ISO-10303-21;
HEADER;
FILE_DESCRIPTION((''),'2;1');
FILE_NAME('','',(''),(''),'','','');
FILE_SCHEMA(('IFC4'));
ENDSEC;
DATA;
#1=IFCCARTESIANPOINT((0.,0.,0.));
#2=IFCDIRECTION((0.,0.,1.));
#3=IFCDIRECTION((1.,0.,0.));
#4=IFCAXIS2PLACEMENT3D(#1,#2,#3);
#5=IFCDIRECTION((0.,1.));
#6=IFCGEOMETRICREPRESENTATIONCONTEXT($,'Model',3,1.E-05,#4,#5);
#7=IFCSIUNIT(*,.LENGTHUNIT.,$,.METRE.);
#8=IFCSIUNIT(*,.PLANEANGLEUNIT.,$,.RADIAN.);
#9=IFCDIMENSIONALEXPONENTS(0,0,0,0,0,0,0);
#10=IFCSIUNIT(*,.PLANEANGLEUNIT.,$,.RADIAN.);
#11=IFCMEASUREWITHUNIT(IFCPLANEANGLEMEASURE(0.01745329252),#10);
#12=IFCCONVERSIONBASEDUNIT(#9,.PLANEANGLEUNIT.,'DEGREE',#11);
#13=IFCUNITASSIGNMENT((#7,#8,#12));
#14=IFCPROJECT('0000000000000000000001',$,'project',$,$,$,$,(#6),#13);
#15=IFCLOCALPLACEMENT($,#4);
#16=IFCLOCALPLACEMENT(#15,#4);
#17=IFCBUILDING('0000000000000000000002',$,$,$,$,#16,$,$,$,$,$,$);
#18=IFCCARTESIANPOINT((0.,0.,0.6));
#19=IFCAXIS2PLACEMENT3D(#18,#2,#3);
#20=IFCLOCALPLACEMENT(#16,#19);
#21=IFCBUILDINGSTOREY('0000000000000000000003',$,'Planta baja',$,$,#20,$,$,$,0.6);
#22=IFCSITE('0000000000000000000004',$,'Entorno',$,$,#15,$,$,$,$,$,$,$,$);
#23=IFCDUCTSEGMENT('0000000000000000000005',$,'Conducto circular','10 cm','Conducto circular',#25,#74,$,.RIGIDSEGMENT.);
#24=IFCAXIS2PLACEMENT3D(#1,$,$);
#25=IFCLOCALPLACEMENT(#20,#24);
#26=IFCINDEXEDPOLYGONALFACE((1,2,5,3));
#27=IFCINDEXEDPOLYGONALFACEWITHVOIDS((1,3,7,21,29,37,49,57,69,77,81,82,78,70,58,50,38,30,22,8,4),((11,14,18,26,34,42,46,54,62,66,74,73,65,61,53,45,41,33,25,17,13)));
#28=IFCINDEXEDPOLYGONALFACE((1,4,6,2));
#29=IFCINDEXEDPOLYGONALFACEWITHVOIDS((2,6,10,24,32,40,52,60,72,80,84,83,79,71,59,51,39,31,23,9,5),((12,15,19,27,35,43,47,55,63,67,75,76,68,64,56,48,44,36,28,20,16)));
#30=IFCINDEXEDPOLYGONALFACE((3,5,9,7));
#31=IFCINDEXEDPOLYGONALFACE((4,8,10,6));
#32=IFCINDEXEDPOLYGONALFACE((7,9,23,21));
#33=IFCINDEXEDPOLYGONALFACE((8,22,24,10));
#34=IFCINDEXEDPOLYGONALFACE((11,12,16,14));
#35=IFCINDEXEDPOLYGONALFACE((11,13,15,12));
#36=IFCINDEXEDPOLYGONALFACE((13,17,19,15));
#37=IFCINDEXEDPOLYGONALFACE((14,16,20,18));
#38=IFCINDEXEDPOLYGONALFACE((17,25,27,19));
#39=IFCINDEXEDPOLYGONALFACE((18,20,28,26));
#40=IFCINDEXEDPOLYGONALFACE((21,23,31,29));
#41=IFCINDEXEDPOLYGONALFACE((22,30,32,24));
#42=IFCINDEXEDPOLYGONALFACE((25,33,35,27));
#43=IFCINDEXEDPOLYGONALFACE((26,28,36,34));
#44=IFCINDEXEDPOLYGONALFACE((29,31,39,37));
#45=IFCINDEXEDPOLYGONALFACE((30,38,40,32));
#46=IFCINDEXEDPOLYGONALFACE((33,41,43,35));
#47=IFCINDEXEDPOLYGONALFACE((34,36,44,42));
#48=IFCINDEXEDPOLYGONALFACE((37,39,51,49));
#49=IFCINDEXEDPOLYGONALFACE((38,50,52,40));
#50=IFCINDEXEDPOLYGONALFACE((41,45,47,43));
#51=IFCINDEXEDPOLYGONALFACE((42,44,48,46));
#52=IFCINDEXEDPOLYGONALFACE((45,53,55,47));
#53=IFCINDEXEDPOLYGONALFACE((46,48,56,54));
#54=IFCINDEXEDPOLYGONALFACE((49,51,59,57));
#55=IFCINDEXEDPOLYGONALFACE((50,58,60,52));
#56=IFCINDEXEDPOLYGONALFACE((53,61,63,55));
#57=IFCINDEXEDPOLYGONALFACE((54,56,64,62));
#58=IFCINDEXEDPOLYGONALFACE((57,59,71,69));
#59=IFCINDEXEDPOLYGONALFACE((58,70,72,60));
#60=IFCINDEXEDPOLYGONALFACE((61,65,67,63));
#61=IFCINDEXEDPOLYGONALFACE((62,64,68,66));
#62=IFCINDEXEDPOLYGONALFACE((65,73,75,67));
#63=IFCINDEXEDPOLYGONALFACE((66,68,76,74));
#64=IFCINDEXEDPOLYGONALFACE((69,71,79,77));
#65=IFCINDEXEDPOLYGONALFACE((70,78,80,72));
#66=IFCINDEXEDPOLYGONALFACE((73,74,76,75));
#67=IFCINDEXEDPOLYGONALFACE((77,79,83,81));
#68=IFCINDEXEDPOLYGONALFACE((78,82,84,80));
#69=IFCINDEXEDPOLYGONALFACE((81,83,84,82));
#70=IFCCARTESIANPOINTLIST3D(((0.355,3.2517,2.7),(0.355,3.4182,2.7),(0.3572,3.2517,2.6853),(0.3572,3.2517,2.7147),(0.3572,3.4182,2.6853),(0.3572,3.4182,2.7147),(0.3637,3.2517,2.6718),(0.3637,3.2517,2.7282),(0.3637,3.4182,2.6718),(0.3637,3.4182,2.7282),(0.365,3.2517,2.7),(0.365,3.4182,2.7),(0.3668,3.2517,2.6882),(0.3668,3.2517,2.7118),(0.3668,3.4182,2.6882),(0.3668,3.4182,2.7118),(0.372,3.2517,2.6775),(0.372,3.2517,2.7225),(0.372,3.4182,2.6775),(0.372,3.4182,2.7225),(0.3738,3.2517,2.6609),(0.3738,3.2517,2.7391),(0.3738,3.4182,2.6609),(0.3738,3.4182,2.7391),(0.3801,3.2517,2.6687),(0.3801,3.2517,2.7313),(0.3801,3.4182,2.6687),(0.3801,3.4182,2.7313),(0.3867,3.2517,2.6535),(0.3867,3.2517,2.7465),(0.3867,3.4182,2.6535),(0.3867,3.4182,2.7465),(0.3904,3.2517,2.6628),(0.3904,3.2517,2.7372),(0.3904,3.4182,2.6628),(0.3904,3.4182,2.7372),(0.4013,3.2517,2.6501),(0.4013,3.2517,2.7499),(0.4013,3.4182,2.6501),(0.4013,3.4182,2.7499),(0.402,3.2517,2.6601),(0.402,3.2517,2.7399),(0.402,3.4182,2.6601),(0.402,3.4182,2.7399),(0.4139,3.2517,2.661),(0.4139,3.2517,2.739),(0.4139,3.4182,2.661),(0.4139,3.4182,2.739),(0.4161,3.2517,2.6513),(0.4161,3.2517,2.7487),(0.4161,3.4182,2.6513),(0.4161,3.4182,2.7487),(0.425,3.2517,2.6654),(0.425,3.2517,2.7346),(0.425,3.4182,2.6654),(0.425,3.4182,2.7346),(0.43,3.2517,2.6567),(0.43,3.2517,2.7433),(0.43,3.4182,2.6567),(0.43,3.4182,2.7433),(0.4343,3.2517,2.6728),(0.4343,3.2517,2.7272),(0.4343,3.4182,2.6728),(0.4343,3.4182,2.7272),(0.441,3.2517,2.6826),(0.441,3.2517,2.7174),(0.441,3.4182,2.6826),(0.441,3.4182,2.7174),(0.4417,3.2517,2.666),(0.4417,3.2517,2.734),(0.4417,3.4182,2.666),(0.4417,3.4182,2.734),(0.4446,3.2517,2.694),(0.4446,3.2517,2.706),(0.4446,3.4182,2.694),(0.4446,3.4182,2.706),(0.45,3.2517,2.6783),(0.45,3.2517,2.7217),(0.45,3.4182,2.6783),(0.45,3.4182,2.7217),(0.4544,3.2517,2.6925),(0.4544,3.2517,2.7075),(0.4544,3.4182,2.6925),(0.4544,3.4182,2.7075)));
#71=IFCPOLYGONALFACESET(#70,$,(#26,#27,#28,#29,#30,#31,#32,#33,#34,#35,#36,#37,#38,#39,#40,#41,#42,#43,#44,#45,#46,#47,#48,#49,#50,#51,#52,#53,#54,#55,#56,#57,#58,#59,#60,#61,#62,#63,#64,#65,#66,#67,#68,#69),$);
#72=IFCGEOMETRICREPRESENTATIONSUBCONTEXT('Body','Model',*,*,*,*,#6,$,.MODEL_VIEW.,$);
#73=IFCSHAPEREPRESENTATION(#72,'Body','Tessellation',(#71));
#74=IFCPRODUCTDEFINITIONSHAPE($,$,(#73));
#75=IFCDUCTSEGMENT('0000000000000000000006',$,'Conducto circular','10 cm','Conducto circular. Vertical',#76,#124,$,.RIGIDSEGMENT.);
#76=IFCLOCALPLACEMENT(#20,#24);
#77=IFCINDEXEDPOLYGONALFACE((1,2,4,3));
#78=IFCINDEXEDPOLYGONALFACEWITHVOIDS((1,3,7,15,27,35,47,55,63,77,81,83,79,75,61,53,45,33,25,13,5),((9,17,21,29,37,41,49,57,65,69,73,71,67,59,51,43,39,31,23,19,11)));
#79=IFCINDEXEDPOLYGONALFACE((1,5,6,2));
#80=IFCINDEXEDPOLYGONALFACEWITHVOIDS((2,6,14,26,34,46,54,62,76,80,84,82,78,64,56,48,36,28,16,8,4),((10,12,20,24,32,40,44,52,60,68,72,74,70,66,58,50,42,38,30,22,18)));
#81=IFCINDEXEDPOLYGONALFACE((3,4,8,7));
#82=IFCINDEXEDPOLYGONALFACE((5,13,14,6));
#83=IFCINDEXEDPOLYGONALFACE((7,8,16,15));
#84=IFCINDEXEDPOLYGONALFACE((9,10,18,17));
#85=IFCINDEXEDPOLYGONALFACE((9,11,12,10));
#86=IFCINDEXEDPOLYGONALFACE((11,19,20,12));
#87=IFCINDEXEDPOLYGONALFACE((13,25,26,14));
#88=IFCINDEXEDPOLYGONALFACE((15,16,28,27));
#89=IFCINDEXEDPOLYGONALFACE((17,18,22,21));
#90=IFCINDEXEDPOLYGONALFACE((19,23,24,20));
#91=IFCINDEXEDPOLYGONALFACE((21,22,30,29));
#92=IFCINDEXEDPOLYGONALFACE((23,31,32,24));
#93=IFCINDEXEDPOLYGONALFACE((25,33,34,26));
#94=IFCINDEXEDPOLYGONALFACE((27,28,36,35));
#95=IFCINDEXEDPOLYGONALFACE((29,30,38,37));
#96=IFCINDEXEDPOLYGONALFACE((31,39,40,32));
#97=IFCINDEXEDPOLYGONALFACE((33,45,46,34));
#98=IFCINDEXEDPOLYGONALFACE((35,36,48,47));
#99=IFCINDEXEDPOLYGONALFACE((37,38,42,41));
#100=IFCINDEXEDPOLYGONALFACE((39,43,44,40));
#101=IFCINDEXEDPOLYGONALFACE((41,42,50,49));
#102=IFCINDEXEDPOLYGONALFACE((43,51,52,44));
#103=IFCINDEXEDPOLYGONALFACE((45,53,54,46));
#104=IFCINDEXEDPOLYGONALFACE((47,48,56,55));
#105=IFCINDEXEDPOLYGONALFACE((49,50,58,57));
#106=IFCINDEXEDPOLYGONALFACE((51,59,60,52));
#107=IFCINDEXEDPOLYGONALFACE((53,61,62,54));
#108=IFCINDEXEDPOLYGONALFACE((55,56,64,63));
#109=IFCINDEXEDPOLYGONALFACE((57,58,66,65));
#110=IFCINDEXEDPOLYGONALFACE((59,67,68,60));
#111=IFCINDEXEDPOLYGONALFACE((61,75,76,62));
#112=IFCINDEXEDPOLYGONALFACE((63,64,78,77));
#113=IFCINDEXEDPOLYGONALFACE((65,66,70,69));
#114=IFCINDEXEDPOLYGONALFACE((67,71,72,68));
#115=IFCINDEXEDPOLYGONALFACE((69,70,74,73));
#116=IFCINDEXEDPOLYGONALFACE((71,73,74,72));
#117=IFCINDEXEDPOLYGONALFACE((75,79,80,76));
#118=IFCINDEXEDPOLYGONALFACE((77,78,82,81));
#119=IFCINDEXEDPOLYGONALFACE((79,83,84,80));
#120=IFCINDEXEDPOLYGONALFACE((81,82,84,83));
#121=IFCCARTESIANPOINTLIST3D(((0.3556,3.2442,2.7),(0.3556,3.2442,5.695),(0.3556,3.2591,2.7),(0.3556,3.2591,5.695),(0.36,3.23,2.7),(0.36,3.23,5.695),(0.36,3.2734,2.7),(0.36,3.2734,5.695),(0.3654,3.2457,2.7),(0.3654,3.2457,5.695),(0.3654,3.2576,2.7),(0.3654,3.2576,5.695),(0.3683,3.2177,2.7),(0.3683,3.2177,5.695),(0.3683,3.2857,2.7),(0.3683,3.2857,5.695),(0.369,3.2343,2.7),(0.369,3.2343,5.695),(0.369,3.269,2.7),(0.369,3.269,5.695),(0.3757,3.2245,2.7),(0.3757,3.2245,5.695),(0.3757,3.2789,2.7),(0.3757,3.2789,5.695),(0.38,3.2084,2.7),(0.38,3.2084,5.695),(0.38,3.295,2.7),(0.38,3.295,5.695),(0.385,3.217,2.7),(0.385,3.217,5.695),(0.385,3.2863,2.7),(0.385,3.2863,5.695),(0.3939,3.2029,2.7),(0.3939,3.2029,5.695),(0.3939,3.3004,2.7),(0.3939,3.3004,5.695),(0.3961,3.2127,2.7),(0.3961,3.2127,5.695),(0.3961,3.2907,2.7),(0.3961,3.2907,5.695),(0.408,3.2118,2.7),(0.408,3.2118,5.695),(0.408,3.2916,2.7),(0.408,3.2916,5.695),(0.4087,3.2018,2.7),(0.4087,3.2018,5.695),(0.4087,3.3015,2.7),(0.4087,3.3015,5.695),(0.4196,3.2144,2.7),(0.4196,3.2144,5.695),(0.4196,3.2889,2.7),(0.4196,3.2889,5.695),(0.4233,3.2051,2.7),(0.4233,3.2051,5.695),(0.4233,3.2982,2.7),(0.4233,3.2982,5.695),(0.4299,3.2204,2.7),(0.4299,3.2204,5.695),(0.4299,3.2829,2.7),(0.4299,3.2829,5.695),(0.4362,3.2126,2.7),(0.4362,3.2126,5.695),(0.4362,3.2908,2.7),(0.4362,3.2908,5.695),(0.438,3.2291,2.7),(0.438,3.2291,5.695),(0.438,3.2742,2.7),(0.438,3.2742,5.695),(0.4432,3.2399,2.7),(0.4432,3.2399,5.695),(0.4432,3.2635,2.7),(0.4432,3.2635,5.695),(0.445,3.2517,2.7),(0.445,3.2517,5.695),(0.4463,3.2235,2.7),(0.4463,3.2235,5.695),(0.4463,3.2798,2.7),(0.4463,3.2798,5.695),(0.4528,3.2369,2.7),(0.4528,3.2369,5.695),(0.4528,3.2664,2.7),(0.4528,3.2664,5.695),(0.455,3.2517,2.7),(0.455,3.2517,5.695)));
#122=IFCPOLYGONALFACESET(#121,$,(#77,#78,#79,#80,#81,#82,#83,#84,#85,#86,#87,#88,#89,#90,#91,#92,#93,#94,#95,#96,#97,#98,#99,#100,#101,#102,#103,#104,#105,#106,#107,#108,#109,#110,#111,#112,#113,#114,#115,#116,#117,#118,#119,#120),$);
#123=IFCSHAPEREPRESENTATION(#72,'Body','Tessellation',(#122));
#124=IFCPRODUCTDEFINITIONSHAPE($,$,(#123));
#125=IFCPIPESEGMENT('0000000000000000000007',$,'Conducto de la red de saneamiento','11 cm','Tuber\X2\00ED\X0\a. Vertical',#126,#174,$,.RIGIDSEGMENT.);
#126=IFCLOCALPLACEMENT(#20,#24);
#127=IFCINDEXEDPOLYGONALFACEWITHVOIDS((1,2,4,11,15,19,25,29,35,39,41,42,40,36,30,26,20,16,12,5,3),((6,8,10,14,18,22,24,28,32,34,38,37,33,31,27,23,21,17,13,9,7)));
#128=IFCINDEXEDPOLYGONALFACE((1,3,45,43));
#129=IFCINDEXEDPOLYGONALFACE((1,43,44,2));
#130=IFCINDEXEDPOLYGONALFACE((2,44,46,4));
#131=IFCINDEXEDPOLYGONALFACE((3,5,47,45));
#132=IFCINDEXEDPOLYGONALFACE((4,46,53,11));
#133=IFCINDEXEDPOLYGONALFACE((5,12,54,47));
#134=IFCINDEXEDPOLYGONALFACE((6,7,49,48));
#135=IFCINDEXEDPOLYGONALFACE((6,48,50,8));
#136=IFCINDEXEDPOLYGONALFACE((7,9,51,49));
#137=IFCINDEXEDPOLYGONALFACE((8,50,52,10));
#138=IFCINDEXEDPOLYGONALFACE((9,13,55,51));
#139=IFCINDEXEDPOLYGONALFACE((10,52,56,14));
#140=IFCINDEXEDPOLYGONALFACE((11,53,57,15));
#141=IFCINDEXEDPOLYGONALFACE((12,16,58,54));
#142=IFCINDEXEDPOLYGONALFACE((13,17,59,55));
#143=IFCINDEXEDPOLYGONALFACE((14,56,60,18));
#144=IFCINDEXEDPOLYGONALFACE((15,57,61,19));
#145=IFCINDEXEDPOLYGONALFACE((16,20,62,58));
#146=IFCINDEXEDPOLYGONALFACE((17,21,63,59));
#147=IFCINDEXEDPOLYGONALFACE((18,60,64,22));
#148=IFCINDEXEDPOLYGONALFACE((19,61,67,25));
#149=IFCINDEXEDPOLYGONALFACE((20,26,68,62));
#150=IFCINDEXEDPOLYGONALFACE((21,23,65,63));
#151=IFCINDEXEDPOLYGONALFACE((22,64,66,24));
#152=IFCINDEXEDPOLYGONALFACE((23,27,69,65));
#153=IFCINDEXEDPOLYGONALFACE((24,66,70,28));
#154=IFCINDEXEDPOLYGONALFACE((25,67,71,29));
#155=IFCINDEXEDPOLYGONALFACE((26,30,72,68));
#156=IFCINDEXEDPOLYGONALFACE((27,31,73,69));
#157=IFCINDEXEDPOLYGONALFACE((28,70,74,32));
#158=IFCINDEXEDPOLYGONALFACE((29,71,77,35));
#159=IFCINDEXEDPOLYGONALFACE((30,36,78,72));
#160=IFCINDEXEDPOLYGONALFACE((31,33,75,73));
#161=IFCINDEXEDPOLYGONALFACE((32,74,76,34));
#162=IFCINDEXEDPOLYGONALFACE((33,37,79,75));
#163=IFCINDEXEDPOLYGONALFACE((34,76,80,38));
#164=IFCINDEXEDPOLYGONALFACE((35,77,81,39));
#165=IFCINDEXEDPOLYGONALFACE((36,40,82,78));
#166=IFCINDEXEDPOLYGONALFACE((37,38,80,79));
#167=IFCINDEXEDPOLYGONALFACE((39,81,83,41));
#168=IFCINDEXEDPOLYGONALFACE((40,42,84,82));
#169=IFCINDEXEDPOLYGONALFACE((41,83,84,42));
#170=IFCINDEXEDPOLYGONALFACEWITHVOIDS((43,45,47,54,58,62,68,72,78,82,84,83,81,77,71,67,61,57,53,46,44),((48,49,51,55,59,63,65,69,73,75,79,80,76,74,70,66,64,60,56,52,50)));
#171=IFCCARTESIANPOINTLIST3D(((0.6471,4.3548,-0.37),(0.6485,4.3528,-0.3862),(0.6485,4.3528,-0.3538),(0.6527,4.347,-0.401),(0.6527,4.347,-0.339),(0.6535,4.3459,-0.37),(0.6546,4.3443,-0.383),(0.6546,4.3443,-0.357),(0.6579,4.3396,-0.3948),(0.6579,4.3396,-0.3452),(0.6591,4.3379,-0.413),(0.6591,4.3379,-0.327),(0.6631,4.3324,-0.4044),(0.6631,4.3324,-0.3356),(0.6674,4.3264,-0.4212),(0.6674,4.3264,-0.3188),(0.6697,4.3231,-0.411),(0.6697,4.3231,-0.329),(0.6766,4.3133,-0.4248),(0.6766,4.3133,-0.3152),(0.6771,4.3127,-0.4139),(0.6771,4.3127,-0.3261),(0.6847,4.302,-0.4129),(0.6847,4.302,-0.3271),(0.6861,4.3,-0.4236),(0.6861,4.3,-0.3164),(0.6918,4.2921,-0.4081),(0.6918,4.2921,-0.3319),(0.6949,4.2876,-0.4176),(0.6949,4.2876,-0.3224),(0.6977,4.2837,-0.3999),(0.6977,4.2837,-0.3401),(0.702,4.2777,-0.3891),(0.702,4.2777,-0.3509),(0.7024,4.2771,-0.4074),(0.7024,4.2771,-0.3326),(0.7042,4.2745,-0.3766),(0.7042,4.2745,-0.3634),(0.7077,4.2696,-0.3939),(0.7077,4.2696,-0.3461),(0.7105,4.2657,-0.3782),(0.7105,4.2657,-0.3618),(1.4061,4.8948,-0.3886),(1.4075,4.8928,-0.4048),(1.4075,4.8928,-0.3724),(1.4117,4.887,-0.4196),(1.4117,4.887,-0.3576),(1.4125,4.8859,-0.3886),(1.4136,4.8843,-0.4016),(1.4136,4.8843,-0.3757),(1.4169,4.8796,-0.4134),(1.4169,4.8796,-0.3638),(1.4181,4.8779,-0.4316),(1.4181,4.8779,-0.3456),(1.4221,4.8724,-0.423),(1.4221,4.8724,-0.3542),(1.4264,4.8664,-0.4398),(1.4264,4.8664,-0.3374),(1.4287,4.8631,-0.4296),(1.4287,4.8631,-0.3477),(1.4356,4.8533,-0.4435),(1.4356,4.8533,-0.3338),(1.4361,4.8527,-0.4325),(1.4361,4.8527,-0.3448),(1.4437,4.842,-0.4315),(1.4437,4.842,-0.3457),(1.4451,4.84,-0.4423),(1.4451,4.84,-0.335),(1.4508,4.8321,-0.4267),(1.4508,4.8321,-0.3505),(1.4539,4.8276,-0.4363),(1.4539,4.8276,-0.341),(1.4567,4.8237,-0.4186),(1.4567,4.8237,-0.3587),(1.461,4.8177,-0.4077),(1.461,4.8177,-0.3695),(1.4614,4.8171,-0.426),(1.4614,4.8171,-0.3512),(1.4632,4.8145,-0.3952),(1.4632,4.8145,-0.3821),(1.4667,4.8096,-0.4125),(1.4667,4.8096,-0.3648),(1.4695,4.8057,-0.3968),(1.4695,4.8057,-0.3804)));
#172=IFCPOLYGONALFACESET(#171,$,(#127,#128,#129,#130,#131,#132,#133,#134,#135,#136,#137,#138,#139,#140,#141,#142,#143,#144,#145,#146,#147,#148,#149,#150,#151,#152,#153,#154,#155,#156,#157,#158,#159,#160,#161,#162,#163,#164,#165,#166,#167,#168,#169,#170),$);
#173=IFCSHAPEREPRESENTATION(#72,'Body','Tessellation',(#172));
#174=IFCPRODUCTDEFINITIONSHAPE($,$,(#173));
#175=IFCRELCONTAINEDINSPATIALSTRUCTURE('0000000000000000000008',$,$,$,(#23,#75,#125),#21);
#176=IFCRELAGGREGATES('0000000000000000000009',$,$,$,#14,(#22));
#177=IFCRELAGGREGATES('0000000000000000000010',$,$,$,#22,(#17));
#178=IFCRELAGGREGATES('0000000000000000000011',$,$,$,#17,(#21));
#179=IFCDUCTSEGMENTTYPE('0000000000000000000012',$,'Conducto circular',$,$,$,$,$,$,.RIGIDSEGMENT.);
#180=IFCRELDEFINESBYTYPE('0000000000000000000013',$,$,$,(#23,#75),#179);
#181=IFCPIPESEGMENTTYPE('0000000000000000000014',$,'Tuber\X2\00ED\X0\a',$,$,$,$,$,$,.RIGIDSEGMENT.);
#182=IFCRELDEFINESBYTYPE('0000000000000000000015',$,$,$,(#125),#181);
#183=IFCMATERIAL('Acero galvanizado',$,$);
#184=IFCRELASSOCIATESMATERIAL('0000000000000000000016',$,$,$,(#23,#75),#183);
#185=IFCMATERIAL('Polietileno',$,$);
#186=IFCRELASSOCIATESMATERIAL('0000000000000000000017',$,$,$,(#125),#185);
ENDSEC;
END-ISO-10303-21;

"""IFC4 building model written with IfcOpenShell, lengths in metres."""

from ifc_helpers import new_model, entity, si_unit, converted_unit, direction, frame, origin_with_axes, origin_2d_with_axis, place, context, subcontext, project, spatial, hollow_circle, extrude, material, type_object, element, save


model = new_model("IFC4")

# Units and contexts
model_context = context("Model", 3, precision=1e-05, world=origin_with_axes(), true_north=direction((0.0, 1.0)))
body_context = subcontext(model_context, "Body", "Model", "MODEL_VIEW")
ifc_project = project(units=[si_unit("LENGTHUNIT", "METRE"), si_unit("PLANEANGLEUNIT", "RADIAN"), converted_unit("PLANEANGLEUNIT", "DEGREE", entity("IfcPlaneAngleMeasure", 0.01745329252), si_unit("PLANEANGLEUNIT", "RADIAN"), dimensions=[0, 0, 0, 0, 0, 0, 0])], contexts=[model_context])

# Site, building, storey
site_placement = place(None, origin_with_axes())
site = spatial("IfcSite", under=ifc_project, at=site_placement, Name="Entorno")
building_placement = place(site_placement, origin_with_axes())
building = spatial("IfcBuilding", under=site, at=building_placement)
storey_placement = place(building_placement, frame((0.0, 0.0, 0.6), z_axis=(0.0, 0.0, 1.0), x_axis=(1.0, 0.0, 0.0)))
storey = spatial("IfcBuildingStorey", under=building, at=storey_placement, Name="Planta baja", Elevation=0.6)

# Shared definitions
ifc_material_1 = material(Name="Polietileno")

# Duct segments
ifc_material_2 = material(Name="Acero galvanizado")
duct_segment_type = type_object("IfcDuctSegmentType", Name="Conducto circular", PredefinedType="RIGIDSEGMENT")
duct_segment_1_placement = place(storey_placement, frame((0.405, 3.2517, 2.7), z_axis=(0.0, 1.0, 0.0), x_axis=(-1.0, 0.0, 0.0)))
element("IfcDuctSegment", 1, at=duct_segment_1_placement, inside=storey, type_object=duct_segment_type, material=ifc_material_2, Name="Conducto circular", Description="10 cm", ObjectType="Conducto circular", PredefinedType="RIGIDSEGMENT", context=body_context, shape_type="SweptSolid", body=[
    extrude(hollow_circle(Radius=0.05, WallThickness=0.01, at=origin_2d_with_axis()), origin_with_axes(), (0.0, 0.0, 1.0), 0.1665),
])
duct_segment_2_placement = place(storey_placement, frame((0.405, 3.2517, 2.7), z_axis=(0.0, 0.0, 1.0), x_axis=(1.0, 0.0, 0.0)))
element("IfcDuctSegment", 2, at=duct_segment_2_placement, inside=storey, type_object=duct_segment_type, material=ifc_material_2, Name="Conducto circular", Description="10 cm", ObjectType="Conducto circular. Vertical", PredefinedType="RIGIDSEGMENT", context=body_context, shape_type="SweptSolid", body=[
    extrude(hollow_circle(Radius=0.05, WallThickness=0.01, at=origin_2d_with_axis()), origin_with_axes(), (0.0, 0.0, 1.0), 2.995),
])

# Pipe segment
pipe_segment_type_1 = type_object("IfcPipeSegmentType", Name="Tubería", PredefinedType="RIGIDSEGMENT")
pipe_segment_1_placement = place(storey_placement, frame((0.679, 4.31, -0.37), z_axis=(0.81482, 0.579714, 0.0), x_axis=(-0.579714, 0.81482, 0.0)))
element("IfcPipeSegment", 3, at=pipe_segment_1_placement, inside=storey, type_object=pipe_segment_type_1, material=ifc_material_1, Name="Conducto de la red de saneamiento", Description="11 cm", ObjectType="Tubería. Vertical", PredefinedType="RIGIDSEGMENT", context=body_context, shape_type="SweptSolid", body=[
    extrude(hollow_circle(Radius=0.055, WallThickness=0.011, at=origin_2d_with_axis()), origin_with_axes(), (0.0, -0.019996, 0.9998), 0.9317),
])

save(model, "model.ifc")
